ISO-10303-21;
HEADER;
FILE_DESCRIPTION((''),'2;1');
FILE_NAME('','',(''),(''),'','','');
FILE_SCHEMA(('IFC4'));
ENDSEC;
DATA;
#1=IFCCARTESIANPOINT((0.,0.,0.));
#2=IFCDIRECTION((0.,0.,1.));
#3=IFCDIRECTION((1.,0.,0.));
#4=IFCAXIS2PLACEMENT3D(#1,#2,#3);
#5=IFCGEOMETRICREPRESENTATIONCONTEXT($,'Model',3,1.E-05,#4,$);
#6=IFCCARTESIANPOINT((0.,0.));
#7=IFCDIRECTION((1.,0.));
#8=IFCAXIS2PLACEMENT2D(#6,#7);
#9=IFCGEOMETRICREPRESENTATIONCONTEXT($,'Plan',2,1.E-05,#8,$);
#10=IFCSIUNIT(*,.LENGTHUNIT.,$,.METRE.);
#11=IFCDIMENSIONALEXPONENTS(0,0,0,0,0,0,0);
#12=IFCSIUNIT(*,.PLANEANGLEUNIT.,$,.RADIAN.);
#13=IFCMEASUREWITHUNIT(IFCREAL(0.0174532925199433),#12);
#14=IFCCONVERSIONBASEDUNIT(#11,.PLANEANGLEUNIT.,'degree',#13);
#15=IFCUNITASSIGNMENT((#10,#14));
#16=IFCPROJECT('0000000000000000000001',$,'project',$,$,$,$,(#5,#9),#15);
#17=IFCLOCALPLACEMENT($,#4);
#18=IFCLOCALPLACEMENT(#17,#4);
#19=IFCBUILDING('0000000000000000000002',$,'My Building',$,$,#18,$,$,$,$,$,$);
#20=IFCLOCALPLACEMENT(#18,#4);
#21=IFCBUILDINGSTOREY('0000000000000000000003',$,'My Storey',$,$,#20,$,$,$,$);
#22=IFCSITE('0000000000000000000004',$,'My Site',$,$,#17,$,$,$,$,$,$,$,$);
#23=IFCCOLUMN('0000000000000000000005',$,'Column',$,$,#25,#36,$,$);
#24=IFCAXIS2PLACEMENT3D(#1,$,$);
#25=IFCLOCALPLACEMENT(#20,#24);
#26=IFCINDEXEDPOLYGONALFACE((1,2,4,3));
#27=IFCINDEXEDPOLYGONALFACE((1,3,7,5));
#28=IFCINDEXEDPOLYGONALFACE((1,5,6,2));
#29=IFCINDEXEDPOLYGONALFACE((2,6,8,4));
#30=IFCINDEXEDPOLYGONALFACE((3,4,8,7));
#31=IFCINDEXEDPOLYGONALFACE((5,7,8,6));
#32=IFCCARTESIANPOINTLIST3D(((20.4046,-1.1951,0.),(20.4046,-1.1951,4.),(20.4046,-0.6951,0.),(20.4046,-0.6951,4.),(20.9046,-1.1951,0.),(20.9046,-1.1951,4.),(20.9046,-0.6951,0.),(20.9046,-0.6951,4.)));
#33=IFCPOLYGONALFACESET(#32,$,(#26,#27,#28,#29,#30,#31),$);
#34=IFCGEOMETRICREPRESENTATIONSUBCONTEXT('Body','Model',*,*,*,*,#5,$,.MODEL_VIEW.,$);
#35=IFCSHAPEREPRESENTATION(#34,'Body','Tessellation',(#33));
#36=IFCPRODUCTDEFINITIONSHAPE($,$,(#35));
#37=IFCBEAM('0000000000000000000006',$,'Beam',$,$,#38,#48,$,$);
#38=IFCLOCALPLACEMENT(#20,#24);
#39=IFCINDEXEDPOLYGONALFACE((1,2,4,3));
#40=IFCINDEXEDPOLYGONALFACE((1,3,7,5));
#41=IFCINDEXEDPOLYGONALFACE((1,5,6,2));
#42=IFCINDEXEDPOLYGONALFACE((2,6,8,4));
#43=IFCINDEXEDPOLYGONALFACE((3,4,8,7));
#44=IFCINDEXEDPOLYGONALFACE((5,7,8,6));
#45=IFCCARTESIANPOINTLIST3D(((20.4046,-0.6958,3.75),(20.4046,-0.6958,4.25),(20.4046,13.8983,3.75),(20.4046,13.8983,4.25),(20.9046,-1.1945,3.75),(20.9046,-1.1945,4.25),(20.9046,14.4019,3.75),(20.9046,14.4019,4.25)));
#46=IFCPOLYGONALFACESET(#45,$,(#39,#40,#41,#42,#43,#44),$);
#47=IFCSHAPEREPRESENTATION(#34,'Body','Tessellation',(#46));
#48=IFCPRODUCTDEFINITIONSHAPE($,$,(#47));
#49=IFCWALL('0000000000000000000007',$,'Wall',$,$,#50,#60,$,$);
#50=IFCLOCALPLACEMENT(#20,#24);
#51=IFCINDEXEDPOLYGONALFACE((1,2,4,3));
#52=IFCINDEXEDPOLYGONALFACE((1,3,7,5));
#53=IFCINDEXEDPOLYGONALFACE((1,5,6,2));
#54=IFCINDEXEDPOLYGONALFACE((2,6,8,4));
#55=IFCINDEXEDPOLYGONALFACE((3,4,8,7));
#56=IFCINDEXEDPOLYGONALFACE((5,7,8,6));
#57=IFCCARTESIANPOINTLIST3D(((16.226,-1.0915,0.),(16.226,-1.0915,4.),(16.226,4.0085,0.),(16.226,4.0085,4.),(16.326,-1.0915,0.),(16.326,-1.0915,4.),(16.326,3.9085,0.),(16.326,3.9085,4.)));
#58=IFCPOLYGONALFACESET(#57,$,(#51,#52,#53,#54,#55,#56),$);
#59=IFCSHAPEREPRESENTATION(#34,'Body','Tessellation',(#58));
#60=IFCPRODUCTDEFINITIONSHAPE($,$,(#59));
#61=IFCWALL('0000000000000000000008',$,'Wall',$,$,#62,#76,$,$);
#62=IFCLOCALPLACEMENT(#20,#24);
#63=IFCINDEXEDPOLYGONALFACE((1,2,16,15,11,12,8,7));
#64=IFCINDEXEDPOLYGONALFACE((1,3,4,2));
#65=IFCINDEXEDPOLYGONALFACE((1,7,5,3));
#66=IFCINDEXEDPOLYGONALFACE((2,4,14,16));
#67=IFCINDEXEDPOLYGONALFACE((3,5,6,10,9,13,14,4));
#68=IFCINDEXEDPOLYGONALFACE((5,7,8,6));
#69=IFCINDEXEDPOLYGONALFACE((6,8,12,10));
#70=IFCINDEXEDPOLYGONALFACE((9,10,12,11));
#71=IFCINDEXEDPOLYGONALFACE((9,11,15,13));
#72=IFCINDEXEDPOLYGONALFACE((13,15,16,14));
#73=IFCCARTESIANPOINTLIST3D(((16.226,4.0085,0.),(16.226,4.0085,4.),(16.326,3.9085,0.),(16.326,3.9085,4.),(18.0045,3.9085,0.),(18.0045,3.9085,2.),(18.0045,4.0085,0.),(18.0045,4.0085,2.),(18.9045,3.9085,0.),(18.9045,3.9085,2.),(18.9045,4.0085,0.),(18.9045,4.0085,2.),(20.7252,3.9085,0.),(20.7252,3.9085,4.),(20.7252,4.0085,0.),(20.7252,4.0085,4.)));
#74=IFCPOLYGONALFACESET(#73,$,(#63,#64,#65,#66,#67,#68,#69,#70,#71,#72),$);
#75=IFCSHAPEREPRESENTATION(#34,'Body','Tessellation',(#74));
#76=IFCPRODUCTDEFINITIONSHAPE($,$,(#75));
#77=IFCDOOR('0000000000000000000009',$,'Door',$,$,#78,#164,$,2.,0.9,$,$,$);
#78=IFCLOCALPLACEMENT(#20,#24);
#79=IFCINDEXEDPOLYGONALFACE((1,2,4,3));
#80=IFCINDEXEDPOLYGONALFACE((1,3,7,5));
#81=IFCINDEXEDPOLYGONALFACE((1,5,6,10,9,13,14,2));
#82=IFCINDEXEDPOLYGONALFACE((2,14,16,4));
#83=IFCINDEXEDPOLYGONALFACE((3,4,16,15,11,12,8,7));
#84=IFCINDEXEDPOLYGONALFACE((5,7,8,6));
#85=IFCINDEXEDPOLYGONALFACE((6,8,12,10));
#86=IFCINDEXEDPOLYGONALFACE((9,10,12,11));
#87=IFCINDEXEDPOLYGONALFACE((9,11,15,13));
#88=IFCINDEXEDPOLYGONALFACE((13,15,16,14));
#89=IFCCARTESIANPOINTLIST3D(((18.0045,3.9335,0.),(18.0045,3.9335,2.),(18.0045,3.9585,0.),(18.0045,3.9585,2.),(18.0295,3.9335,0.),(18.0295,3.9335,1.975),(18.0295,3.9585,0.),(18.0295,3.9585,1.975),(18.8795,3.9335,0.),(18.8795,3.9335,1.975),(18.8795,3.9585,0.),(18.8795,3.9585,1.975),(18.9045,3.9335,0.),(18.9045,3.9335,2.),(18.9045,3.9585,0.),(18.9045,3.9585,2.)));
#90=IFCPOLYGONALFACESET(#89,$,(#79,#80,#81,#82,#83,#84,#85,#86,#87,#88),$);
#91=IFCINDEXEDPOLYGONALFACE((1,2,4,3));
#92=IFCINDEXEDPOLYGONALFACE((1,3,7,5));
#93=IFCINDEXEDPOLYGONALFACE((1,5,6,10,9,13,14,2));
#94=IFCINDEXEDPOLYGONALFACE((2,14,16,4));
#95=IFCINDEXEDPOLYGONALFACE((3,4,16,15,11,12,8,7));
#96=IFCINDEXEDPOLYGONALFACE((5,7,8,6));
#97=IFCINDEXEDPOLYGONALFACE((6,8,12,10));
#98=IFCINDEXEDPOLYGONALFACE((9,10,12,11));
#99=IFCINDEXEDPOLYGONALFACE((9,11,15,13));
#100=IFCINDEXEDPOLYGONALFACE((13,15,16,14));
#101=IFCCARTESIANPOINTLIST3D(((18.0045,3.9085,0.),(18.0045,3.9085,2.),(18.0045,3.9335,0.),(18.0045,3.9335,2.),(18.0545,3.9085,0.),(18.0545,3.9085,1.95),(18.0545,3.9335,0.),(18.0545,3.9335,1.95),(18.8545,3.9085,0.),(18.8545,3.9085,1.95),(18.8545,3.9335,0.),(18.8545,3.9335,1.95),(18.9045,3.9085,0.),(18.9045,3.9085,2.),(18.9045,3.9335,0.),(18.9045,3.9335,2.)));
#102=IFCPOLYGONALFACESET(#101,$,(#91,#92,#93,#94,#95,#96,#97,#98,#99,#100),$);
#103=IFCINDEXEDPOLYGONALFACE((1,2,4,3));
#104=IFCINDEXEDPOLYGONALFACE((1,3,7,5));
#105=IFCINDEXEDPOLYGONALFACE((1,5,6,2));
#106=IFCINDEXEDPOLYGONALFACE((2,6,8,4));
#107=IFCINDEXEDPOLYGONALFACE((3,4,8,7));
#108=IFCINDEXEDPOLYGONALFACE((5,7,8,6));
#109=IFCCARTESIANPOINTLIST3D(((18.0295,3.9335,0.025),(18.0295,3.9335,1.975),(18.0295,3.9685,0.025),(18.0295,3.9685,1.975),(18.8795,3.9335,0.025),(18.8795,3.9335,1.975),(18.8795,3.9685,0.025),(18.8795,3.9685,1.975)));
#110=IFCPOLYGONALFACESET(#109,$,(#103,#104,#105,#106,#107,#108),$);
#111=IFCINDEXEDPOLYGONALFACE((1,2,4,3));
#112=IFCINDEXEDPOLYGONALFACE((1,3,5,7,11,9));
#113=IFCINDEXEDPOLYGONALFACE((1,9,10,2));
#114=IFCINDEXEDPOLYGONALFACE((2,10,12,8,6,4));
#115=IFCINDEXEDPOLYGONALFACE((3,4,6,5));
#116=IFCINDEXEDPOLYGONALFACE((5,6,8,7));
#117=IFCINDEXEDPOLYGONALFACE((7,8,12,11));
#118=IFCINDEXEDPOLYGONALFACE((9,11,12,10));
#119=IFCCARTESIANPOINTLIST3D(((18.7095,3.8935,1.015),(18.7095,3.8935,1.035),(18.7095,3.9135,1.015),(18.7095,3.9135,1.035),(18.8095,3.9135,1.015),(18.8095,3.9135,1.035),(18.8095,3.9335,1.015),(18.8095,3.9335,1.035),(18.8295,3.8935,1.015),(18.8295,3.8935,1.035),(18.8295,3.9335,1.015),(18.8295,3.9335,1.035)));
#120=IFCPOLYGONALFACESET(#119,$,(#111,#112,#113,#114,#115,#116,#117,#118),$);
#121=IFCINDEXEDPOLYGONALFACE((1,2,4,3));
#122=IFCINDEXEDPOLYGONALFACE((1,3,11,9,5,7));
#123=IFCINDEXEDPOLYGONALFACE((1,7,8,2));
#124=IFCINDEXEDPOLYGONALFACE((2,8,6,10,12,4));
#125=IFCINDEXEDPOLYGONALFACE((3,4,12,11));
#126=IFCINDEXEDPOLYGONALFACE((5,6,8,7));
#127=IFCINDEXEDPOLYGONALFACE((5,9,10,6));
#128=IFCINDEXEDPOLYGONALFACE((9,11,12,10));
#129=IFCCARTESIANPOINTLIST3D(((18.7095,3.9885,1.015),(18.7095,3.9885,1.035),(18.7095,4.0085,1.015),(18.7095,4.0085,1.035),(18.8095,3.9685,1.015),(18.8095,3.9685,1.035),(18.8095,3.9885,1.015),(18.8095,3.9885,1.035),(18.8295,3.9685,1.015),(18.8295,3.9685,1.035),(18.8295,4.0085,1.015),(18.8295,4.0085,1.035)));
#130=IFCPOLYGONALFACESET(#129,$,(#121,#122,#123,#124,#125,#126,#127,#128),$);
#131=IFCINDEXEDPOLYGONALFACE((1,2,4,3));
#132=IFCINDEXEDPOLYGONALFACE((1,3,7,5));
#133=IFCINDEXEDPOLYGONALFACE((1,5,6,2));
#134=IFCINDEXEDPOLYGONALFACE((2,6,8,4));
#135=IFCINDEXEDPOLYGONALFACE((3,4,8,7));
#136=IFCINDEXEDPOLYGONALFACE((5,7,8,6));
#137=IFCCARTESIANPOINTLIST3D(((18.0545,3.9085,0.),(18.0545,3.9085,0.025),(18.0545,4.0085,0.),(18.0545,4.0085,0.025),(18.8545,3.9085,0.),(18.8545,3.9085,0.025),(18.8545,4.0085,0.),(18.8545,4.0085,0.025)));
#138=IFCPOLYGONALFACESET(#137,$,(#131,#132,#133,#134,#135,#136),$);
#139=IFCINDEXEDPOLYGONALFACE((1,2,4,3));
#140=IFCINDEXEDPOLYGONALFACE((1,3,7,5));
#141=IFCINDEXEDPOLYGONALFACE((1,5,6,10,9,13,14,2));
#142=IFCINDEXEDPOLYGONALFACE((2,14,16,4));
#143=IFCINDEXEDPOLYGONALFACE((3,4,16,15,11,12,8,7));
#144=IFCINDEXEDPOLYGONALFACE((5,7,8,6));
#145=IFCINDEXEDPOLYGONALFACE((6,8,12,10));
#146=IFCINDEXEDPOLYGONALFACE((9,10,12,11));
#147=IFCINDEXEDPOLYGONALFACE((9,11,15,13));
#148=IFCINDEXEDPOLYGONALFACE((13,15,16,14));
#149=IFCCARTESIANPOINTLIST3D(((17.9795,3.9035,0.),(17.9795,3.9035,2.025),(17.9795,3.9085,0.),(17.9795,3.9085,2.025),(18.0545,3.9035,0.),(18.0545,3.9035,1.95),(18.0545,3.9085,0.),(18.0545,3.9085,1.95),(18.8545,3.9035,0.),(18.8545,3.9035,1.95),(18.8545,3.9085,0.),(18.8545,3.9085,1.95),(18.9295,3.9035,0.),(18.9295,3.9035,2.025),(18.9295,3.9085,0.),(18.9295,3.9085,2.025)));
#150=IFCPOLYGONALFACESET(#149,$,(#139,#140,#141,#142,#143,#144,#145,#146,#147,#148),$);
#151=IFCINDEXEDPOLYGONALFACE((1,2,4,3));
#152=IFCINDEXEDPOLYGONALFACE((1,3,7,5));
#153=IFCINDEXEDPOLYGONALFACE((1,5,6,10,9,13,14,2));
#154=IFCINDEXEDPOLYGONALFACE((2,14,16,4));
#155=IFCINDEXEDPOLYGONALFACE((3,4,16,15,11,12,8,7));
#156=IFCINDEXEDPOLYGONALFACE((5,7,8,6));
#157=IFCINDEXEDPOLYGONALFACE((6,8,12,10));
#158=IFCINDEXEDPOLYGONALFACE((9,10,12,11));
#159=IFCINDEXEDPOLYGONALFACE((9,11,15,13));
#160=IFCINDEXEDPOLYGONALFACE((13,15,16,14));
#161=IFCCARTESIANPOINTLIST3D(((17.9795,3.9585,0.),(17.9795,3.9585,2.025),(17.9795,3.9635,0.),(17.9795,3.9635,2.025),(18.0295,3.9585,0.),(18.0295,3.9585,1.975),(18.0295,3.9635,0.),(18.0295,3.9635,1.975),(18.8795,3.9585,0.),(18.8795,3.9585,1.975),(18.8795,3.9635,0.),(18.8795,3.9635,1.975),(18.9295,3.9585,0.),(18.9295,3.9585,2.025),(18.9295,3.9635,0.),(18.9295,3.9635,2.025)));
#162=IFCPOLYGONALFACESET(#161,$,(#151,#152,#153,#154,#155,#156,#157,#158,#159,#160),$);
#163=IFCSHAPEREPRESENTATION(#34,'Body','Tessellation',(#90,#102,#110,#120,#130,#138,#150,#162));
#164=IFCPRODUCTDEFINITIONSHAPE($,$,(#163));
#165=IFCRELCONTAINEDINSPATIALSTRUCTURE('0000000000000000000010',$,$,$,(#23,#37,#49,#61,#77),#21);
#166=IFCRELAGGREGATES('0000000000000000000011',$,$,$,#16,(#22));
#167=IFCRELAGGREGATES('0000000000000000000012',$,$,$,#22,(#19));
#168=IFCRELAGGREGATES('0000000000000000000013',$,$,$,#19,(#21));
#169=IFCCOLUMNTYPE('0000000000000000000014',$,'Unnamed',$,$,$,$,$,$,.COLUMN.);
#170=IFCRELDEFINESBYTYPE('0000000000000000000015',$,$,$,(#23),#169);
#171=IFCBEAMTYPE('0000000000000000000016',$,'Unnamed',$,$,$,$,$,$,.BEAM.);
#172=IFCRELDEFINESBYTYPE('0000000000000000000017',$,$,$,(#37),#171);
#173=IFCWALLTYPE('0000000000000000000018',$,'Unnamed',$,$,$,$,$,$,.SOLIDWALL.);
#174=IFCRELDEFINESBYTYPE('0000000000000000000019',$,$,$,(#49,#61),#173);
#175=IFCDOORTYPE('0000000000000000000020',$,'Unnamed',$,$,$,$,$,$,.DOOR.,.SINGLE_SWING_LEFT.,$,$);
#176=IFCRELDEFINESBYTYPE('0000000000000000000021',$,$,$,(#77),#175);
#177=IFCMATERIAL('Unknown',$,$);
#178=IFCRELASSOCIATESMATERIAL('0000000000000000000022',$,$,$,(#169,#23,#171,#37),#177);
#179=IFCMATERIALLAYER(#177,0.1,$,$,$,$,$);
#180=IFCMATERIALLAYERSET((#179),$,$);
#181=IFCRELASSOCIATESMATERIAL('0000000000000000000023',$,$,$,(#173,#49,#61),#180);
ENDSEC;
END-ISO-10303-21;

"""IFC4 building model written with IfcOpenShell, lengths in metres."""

from ifc_helpers import new_model, entity, si_unit, converted_unit, frame, origin_with_axes, origin_2d_with_axis, place, context, subcontext, project, spatial, line, indexed_curve, rectangle, outline, extrude, clip, halfspace, shape, source, transform, mapped, material, layer, layer_set, layer_usage, material_profile, profile_set, profile_usage, type_object, type_shapes, element, fill, save


model = new_model("IFC4")

# Units and contexts
model_context = context("Model", 3, precision=1e-05, world=origin_with_axes())
plan_context = context("Plan", 2, precision=1e-05, world=origin_2d_with_axis())
body_context_1 = subcontext(model_context, "Body", "Model", "MODEL_VIEW")
body_context_2 = subcontext(plan_context, "Body", "Plan", "PLAN_VIEW")
ifc_project = project(units=[si_unit("LENGTHUNIT", "METRE"), converted_unit("PLANEANGLEUNIT", "degree", entity("IfcReal", 0.0174532925199433), si_unit("PLANEANGLEUNIT", "RADIAN"), dimensions=[0, 0, 0, 0, 0, 0, 0])], contexts=[model_context, plan_context])

# Site, building, storey
site_placement = place(None, origin_with_axes())
site = spatial("IfcSite", under=ifc_project, at=site_placement, Name="My Site")
building_placement = place(site_placement, origin_with_axes())
building = spatial("IfcBuilding", under=site, at=building_placement, Name="My Building")
storey_placement = place(building_placement, origin_with_axes())
storey = spatial("IfcBuildingStorey", under=building, at=storey_placement, Name="My Storey")

# Column
ifc_material = material(Name="Unknown")
ifc_material_profile_1 = material_profile(ifc_material, rectangle(XDim=0.5, YDim=0.5))
ifc_profile_set_1 = profile_set([ifc_material_profile_1])
ifc_profile_usage_1 = profile_usage(ifc_profile_set_1, cardinal=5)
column_type = type_object("IfcColumnType", Name="Unnamed", PredefinedType="COLUMN", material=ifc_profile_set_1)
column_placement = place(storey_placement, frame((20.6546, -0.9451, 0.0), z_axis=(0.0, 0.0, 1.0), x_axis=(1.0, 0.0, 0.0)))
element("IfcColumn", 1, at=column_placement, inside=storey, type_object=column_type, material=ifc_profile_usage_1, Name="Column", context=body_context_1, shape_type="SweptSolid", body=[
    extrude(rectangle(XDim=0.5, YDim=0.5), origin_with_axes(), (0.0, 0.0, 1.0), 4.0),
])

# Beam
ifc_material_profile_2 = material_profile(ifc_material, rectangle(XDim=0.5, YDim=0.5))
ifc_profile_set_2 = profile_set([ifc_material_profile_2])
ifc_profile_usage_2 = profile_usage(ifc_profile_set_2, cardinal=5)
beam_type = type_object("IfcBeamType", Name="Unnamed", PredefinedType="BEAM", material=ifc_profile_set_2)
beam_placement = place(storey_placement, frame((20.6546, -1.6951, 4.0), z_axis=(0.0, 1.0, 0.0), x_axis=(-1.0, 0.0, 0.0)))
element("IfcBeam", 2, at=beam_placement, inside=storey, type_object=beam_type, material=ifc_profile_usage_2, Name="Beam", context=body_context_1, shape_type="Clipping", body=[
    clip(clip(extrude(rectangle(XDim=0.5, YDim=0.5), origin_with_axes(), (0.0, 0.0, 1.0), 16.5952), halfspace(frame((-0.25, -4.0, 16.097), z_axis=(0.709671, 0.0, 0.704534), x_axis=(0.0, -1.0, 0.0)), False)), halfspace(frame((-0.25, -4.0, 0.5007), z_axis=(0.706167, 0.0, -0.708046), x_axis=(0.0, -1.0, 0.0)), False)),
])

# Shared definitions
ifc_layer = layer(ifc_material, 0.1)
ifc_layer_set = layer_set([ifc_layer])
wall_type = type_object("IfcWallType", Name="Unnamed", PredefinedType="SOLIDWALL", material=ifc_layer_set)
shared_shape_1 = source(origin_with_axes(), body_context_1, "Body", "SweptSolid", [
    extrude(outline(indexed_curve([(0.0, 0.0), (0.9, 0.0), (0.9, 2.0), (0.0, 2.0)], segments=[line(1, 2, 3, 4, 1)])), frame((0.0, -0.6, 0.0), z_axis=(0.0, -1.0, 0.0), x_axis=(1.0, 0.0, 0.0)), (0.0, 0.0, -1.0), 1.2),
])
door_type = type_object("IfcDoorType", Name="Unnamed", OperationType="SINGLE_SWING_LEFT", PredefinedType="DOOR")
shared_shape_2 = source(origin_with_axes(), body_context_1, "Body", "SweptSolid", [
    extrude(outline(indexed_curve([(0.0, 0.0), (0.0, 2.0), (0.9, 2.0), (0.9, 0.0), (0.875, 0.0), (0.875, 1.975), (0.025, 1.975), (0.025, 0.0)], segments=[line(1, 2, 3, 4, 5, 6, 7, 8, 1)])), frame((0.0, 0.025, 0.0), z_axis=(0.0, -1.0, 0.0), x_axis=(1.0, 0.0, 0.0)), (0.0, 0.0, -1.0), 0.025),
    extrude(outline(indexed_curve([(0.0, 0.0), (0.0, 2.0), (0.9, 2.0), (0.9, 0.0), (0.85, 0.0), (0.85, 1.95), (0.05, 1.95), (0.05, 0.0)], segments=[line(1, 2, 3, 4, 5, 6, 7, 8, 1)])), frame((0.0, 0.0, 0.0), z_axis=(0.0, -1.0, 0.0), x_axis=(1.0, 0.0, 0.0)), (0.0, 0.0, -1.0), 0.025),
    extrude(outline(indexed_curve([(0.0, 0.0), (0.85, 0.0), (0.85, 0.035), (0.0, 0.035)], segments=[line(1, 2, 3, 4, 1)])), frame((0.025, 0.025, 0.025), z_axis=(0.0, 0.0, 1.0), x_axis=(1.0, 0.0, 0.0)), (0.0, 0.0, 1.0), 1.95),
    extrude(outline(indexed_curve([(0.0, 0.0), (0.0, -0.04), (-0.12, -0.04), (-0.12, -0.02), (-0.02, -0.02), (-0.02, 0.0)], segments=[line(1, 2, 3, 4, 5, 6, 1)])), frame((0.825, 0.025, 1.015), z_axis=(0.0, 0.0, 1.0), x_axis=(1.0, 0.0, 0.0)), (0.0, 0.0, 1.0), 0.02),
    extrude(outline(indexed_curve([(0.0, 0.0), (0.0, 0.04), (-0.12, 0.04), (-0.12, 0.02), (-0.02, 0.02), (-0.02, 0.0)], segments=[line(1, 2, 3, 4, 5, 6, 1)])), frame((0.825, 0.06, 1.015), z_axis=(0.0, 0.0, 1.0), x_axis=(1.0, 0.0, 0.0)), (0.0, 0.0, 1.0), 0.02),
    extrude(outline(indexed_curve([(0.0, 0.0), (0.8, 0.0), (0.8, 0.1), (0.0, 0.1)], segments=[line(1, 2, 3, 4, 1)])), frame((0.05, 0.0, 0.0), z_axis=(0.0, 0.0, 1.0), x_axis=(1.0, 0.0, 0.0)), (0.0, 0.0, 1.0), 0.025),
    extrude(outline(indexed_curve([(0.0, 0.0), (0.0, 2.025), (0.95, 2.025), (0.95, 0.0), (0.875, 0.0), (0.875, 1.95), (0.075, 1.95), (0.075, 0.0)], segments=[line(1, 2, 3, 4, 5, 6, 7, 8, 1)])), frame((-0.025, -0.005, 0.0), z_axis=(0.0, -1.0, 0.0), x_axis=(1.0, 0.0, 0.0)), (0.0, 0.0, -1.0), 0.005),
    extrude(outline(indexed_curve([(0.0, 0.0), (0.0, 2.025), (0.95, 2.025), (0.95, 0.0), (0.9, 0.0), (0.9, 1.975), (0.05, 1.975), (0.05, 0.0)], segments=[line(1, 2, 3, 4, 5, 6, 7, 8, 1)])), frame((-0.025, 0.05, 0.0), z_axis=(0.0, -1.0, 0.0), x_axis=(1.0, 0.0, 0.0)), (0.0, 0.0, -1.0), 0.005),
])
shared_shape_3 = source(origin_with_axes(), body_context_2, "Body", "Curve2D", [
    entity("IfcIndexedPolyCurve", entity("IfcCartesianPointList2D", [[0.0, 0.0], [0.0, 0.05], [0.025, 0.05], [0.025, 0.025], [0.05, 0.025], [0.05, 0.0]]), [entity("IfcLineIndex", [1, 2, 3, 4, 5, 6, 1])]),
    entity("IfcIndexedPolyCurve", entity("IfcCartesianPointList2D", [[0.9, 0.0], [0.9, 0.05], [0.875, 0.05], [0.875, 0.025], [0.85, 0.025], [0.85, 0.0]]), [entity("IfcLineIndex", [1, 2, 3, 4, 5, 6, 1])]),
    entity("IfcTrimmedCurve", entity("IfcEllipse", entity("IfcAxis2Placement2D", entity("IfcCartesianPoint", [0.06, 0.05]), entity("IfcDirection", [1.0, 0.0])), 0.815, 0.85), [entity("IfcCartesianPoint", [0.875, 0.05])], [entity("IfcCartesianPoint", [0.06, 0.9])], True, "CARTESIAN"),
    entity("IfcIndexedPolyCurve", entity("IfcCartesianPointList2D", [[0.025, 0.05], [0.06, 0.05], [0.06, 0.9], [0.025, 0.9]]), [entity("IfcLineIndex", [1, 2, 3, 4, 1])]),
])
type_shapes(door_type, [shared_shape_2, shared_shape_3])

# Wall
ifc_layer_usage_1 = layer_usage(ifc_layer_set, "AXIS2", "POSITIVE", 0.0)
wall_1_placement = place(storey_placement, frame((16.326, -1.0915, 0.0), z_axis=(0.0, 0.0, 1.0), x_axis=(0.0, 1.0, 0.0)))
element("IfcWall", 3, at=wall_1_placement, inside=storey, type_object=wall_type, material=ifc_layer_usage_1, Name="Wall", context=body_context_1, shape_type="SweptSolid", body=[
    extrude(outline(indexed_curve([(0.0, 0.0), (0.0, 0.1), (5.1, 0.1), (5.0, 0.0)], segments=[line(1, 2, 3, 4, 1)])), origin_with_axes(), (0.0, 0.0, 1.0), 4.0),
])

# Wall, opening, door
ifc_layer_usage_2 = layer_usage(ifc_layer_set, "AXIS2", "POSITIVE", 0.0)
wall_2_placement = place(storey_placement, frame((16.326, 3.9085, 0.0), z_axis=(0.0, 0.0, 1.0), x_axis=(1.0, 0.0, 0.0)))
wall_2 = element("IfcWall", 4, at=wall_2_placement, inside=storey, type_object=wall_type, material=ifc_layer_usage_2, Name="Wall", context=body_context_1, shape_type="SweptSolid", body=[
    extrude(outline(indexed_curve([(0.0, 0.0), (-0.1, 0.1), (4.3992, 0.1), (4.3992, 0.0)], segments=[line(1, 2, 3, 4, 1)])), origin_with_axes(), (0.0, 0.0, 1.0), 4.0),
])
opening_1_placement = place(wall_2_placement, frame((1.6785, 0.0, 0.0), z_axis=(0.0, 0.0, 1.0), x_axis=(1.0, 0.0, 0.0)))
opening_1 = element("IfcOpeningElement", 5, at=opening_1_placement, cuts=wall_2, PredefinedType="OPENING", context=body_context_1, shape_type="MappedRepresentation", body=[
    mapped(shared_shape_1, transform((0.0, 0.0, 0.0), x_axis=(1.0, 0.0, 0.0), y_axis=(0.0, 1.0, 0.0), z_axis=(0.0, 0.0, 1.0), scale=1.0)),
])
door_1_placement = place(opening_1_placement, origin_with_axes())
door_1 = element("IfcDoor", 6, at=door_1_placement, inside=storey, type_object=door_type, Name="Door", OverallHeight=2.0, OverallWidth=0.9, shapes=[
    shape(body_context_1, "Body", "MappedRepresentation", [mapped(shared_shape_2, transform((0.0, 0.0, 0.0), x_axis=(1.0, 0.0, 0.0), y_axis=(0.0, 1.0, 0.0), z_axis=(0.0, 0.0, 1.0), scale=1.0))]),
    shape(body_context_2, "Body", "MappedRepresentation", [mapped(shared_shape_3, transform((0.0, 0.0, 0.0), x_axis=(1.0, 0.0, 0.0), y_axis=(0.0, 1.0, 0.0), z_axis=(0.0, 0.0, 1.0), scale=1.0))]),
])
fill(opening_1, door_1)

save(model, "model.ifc")
